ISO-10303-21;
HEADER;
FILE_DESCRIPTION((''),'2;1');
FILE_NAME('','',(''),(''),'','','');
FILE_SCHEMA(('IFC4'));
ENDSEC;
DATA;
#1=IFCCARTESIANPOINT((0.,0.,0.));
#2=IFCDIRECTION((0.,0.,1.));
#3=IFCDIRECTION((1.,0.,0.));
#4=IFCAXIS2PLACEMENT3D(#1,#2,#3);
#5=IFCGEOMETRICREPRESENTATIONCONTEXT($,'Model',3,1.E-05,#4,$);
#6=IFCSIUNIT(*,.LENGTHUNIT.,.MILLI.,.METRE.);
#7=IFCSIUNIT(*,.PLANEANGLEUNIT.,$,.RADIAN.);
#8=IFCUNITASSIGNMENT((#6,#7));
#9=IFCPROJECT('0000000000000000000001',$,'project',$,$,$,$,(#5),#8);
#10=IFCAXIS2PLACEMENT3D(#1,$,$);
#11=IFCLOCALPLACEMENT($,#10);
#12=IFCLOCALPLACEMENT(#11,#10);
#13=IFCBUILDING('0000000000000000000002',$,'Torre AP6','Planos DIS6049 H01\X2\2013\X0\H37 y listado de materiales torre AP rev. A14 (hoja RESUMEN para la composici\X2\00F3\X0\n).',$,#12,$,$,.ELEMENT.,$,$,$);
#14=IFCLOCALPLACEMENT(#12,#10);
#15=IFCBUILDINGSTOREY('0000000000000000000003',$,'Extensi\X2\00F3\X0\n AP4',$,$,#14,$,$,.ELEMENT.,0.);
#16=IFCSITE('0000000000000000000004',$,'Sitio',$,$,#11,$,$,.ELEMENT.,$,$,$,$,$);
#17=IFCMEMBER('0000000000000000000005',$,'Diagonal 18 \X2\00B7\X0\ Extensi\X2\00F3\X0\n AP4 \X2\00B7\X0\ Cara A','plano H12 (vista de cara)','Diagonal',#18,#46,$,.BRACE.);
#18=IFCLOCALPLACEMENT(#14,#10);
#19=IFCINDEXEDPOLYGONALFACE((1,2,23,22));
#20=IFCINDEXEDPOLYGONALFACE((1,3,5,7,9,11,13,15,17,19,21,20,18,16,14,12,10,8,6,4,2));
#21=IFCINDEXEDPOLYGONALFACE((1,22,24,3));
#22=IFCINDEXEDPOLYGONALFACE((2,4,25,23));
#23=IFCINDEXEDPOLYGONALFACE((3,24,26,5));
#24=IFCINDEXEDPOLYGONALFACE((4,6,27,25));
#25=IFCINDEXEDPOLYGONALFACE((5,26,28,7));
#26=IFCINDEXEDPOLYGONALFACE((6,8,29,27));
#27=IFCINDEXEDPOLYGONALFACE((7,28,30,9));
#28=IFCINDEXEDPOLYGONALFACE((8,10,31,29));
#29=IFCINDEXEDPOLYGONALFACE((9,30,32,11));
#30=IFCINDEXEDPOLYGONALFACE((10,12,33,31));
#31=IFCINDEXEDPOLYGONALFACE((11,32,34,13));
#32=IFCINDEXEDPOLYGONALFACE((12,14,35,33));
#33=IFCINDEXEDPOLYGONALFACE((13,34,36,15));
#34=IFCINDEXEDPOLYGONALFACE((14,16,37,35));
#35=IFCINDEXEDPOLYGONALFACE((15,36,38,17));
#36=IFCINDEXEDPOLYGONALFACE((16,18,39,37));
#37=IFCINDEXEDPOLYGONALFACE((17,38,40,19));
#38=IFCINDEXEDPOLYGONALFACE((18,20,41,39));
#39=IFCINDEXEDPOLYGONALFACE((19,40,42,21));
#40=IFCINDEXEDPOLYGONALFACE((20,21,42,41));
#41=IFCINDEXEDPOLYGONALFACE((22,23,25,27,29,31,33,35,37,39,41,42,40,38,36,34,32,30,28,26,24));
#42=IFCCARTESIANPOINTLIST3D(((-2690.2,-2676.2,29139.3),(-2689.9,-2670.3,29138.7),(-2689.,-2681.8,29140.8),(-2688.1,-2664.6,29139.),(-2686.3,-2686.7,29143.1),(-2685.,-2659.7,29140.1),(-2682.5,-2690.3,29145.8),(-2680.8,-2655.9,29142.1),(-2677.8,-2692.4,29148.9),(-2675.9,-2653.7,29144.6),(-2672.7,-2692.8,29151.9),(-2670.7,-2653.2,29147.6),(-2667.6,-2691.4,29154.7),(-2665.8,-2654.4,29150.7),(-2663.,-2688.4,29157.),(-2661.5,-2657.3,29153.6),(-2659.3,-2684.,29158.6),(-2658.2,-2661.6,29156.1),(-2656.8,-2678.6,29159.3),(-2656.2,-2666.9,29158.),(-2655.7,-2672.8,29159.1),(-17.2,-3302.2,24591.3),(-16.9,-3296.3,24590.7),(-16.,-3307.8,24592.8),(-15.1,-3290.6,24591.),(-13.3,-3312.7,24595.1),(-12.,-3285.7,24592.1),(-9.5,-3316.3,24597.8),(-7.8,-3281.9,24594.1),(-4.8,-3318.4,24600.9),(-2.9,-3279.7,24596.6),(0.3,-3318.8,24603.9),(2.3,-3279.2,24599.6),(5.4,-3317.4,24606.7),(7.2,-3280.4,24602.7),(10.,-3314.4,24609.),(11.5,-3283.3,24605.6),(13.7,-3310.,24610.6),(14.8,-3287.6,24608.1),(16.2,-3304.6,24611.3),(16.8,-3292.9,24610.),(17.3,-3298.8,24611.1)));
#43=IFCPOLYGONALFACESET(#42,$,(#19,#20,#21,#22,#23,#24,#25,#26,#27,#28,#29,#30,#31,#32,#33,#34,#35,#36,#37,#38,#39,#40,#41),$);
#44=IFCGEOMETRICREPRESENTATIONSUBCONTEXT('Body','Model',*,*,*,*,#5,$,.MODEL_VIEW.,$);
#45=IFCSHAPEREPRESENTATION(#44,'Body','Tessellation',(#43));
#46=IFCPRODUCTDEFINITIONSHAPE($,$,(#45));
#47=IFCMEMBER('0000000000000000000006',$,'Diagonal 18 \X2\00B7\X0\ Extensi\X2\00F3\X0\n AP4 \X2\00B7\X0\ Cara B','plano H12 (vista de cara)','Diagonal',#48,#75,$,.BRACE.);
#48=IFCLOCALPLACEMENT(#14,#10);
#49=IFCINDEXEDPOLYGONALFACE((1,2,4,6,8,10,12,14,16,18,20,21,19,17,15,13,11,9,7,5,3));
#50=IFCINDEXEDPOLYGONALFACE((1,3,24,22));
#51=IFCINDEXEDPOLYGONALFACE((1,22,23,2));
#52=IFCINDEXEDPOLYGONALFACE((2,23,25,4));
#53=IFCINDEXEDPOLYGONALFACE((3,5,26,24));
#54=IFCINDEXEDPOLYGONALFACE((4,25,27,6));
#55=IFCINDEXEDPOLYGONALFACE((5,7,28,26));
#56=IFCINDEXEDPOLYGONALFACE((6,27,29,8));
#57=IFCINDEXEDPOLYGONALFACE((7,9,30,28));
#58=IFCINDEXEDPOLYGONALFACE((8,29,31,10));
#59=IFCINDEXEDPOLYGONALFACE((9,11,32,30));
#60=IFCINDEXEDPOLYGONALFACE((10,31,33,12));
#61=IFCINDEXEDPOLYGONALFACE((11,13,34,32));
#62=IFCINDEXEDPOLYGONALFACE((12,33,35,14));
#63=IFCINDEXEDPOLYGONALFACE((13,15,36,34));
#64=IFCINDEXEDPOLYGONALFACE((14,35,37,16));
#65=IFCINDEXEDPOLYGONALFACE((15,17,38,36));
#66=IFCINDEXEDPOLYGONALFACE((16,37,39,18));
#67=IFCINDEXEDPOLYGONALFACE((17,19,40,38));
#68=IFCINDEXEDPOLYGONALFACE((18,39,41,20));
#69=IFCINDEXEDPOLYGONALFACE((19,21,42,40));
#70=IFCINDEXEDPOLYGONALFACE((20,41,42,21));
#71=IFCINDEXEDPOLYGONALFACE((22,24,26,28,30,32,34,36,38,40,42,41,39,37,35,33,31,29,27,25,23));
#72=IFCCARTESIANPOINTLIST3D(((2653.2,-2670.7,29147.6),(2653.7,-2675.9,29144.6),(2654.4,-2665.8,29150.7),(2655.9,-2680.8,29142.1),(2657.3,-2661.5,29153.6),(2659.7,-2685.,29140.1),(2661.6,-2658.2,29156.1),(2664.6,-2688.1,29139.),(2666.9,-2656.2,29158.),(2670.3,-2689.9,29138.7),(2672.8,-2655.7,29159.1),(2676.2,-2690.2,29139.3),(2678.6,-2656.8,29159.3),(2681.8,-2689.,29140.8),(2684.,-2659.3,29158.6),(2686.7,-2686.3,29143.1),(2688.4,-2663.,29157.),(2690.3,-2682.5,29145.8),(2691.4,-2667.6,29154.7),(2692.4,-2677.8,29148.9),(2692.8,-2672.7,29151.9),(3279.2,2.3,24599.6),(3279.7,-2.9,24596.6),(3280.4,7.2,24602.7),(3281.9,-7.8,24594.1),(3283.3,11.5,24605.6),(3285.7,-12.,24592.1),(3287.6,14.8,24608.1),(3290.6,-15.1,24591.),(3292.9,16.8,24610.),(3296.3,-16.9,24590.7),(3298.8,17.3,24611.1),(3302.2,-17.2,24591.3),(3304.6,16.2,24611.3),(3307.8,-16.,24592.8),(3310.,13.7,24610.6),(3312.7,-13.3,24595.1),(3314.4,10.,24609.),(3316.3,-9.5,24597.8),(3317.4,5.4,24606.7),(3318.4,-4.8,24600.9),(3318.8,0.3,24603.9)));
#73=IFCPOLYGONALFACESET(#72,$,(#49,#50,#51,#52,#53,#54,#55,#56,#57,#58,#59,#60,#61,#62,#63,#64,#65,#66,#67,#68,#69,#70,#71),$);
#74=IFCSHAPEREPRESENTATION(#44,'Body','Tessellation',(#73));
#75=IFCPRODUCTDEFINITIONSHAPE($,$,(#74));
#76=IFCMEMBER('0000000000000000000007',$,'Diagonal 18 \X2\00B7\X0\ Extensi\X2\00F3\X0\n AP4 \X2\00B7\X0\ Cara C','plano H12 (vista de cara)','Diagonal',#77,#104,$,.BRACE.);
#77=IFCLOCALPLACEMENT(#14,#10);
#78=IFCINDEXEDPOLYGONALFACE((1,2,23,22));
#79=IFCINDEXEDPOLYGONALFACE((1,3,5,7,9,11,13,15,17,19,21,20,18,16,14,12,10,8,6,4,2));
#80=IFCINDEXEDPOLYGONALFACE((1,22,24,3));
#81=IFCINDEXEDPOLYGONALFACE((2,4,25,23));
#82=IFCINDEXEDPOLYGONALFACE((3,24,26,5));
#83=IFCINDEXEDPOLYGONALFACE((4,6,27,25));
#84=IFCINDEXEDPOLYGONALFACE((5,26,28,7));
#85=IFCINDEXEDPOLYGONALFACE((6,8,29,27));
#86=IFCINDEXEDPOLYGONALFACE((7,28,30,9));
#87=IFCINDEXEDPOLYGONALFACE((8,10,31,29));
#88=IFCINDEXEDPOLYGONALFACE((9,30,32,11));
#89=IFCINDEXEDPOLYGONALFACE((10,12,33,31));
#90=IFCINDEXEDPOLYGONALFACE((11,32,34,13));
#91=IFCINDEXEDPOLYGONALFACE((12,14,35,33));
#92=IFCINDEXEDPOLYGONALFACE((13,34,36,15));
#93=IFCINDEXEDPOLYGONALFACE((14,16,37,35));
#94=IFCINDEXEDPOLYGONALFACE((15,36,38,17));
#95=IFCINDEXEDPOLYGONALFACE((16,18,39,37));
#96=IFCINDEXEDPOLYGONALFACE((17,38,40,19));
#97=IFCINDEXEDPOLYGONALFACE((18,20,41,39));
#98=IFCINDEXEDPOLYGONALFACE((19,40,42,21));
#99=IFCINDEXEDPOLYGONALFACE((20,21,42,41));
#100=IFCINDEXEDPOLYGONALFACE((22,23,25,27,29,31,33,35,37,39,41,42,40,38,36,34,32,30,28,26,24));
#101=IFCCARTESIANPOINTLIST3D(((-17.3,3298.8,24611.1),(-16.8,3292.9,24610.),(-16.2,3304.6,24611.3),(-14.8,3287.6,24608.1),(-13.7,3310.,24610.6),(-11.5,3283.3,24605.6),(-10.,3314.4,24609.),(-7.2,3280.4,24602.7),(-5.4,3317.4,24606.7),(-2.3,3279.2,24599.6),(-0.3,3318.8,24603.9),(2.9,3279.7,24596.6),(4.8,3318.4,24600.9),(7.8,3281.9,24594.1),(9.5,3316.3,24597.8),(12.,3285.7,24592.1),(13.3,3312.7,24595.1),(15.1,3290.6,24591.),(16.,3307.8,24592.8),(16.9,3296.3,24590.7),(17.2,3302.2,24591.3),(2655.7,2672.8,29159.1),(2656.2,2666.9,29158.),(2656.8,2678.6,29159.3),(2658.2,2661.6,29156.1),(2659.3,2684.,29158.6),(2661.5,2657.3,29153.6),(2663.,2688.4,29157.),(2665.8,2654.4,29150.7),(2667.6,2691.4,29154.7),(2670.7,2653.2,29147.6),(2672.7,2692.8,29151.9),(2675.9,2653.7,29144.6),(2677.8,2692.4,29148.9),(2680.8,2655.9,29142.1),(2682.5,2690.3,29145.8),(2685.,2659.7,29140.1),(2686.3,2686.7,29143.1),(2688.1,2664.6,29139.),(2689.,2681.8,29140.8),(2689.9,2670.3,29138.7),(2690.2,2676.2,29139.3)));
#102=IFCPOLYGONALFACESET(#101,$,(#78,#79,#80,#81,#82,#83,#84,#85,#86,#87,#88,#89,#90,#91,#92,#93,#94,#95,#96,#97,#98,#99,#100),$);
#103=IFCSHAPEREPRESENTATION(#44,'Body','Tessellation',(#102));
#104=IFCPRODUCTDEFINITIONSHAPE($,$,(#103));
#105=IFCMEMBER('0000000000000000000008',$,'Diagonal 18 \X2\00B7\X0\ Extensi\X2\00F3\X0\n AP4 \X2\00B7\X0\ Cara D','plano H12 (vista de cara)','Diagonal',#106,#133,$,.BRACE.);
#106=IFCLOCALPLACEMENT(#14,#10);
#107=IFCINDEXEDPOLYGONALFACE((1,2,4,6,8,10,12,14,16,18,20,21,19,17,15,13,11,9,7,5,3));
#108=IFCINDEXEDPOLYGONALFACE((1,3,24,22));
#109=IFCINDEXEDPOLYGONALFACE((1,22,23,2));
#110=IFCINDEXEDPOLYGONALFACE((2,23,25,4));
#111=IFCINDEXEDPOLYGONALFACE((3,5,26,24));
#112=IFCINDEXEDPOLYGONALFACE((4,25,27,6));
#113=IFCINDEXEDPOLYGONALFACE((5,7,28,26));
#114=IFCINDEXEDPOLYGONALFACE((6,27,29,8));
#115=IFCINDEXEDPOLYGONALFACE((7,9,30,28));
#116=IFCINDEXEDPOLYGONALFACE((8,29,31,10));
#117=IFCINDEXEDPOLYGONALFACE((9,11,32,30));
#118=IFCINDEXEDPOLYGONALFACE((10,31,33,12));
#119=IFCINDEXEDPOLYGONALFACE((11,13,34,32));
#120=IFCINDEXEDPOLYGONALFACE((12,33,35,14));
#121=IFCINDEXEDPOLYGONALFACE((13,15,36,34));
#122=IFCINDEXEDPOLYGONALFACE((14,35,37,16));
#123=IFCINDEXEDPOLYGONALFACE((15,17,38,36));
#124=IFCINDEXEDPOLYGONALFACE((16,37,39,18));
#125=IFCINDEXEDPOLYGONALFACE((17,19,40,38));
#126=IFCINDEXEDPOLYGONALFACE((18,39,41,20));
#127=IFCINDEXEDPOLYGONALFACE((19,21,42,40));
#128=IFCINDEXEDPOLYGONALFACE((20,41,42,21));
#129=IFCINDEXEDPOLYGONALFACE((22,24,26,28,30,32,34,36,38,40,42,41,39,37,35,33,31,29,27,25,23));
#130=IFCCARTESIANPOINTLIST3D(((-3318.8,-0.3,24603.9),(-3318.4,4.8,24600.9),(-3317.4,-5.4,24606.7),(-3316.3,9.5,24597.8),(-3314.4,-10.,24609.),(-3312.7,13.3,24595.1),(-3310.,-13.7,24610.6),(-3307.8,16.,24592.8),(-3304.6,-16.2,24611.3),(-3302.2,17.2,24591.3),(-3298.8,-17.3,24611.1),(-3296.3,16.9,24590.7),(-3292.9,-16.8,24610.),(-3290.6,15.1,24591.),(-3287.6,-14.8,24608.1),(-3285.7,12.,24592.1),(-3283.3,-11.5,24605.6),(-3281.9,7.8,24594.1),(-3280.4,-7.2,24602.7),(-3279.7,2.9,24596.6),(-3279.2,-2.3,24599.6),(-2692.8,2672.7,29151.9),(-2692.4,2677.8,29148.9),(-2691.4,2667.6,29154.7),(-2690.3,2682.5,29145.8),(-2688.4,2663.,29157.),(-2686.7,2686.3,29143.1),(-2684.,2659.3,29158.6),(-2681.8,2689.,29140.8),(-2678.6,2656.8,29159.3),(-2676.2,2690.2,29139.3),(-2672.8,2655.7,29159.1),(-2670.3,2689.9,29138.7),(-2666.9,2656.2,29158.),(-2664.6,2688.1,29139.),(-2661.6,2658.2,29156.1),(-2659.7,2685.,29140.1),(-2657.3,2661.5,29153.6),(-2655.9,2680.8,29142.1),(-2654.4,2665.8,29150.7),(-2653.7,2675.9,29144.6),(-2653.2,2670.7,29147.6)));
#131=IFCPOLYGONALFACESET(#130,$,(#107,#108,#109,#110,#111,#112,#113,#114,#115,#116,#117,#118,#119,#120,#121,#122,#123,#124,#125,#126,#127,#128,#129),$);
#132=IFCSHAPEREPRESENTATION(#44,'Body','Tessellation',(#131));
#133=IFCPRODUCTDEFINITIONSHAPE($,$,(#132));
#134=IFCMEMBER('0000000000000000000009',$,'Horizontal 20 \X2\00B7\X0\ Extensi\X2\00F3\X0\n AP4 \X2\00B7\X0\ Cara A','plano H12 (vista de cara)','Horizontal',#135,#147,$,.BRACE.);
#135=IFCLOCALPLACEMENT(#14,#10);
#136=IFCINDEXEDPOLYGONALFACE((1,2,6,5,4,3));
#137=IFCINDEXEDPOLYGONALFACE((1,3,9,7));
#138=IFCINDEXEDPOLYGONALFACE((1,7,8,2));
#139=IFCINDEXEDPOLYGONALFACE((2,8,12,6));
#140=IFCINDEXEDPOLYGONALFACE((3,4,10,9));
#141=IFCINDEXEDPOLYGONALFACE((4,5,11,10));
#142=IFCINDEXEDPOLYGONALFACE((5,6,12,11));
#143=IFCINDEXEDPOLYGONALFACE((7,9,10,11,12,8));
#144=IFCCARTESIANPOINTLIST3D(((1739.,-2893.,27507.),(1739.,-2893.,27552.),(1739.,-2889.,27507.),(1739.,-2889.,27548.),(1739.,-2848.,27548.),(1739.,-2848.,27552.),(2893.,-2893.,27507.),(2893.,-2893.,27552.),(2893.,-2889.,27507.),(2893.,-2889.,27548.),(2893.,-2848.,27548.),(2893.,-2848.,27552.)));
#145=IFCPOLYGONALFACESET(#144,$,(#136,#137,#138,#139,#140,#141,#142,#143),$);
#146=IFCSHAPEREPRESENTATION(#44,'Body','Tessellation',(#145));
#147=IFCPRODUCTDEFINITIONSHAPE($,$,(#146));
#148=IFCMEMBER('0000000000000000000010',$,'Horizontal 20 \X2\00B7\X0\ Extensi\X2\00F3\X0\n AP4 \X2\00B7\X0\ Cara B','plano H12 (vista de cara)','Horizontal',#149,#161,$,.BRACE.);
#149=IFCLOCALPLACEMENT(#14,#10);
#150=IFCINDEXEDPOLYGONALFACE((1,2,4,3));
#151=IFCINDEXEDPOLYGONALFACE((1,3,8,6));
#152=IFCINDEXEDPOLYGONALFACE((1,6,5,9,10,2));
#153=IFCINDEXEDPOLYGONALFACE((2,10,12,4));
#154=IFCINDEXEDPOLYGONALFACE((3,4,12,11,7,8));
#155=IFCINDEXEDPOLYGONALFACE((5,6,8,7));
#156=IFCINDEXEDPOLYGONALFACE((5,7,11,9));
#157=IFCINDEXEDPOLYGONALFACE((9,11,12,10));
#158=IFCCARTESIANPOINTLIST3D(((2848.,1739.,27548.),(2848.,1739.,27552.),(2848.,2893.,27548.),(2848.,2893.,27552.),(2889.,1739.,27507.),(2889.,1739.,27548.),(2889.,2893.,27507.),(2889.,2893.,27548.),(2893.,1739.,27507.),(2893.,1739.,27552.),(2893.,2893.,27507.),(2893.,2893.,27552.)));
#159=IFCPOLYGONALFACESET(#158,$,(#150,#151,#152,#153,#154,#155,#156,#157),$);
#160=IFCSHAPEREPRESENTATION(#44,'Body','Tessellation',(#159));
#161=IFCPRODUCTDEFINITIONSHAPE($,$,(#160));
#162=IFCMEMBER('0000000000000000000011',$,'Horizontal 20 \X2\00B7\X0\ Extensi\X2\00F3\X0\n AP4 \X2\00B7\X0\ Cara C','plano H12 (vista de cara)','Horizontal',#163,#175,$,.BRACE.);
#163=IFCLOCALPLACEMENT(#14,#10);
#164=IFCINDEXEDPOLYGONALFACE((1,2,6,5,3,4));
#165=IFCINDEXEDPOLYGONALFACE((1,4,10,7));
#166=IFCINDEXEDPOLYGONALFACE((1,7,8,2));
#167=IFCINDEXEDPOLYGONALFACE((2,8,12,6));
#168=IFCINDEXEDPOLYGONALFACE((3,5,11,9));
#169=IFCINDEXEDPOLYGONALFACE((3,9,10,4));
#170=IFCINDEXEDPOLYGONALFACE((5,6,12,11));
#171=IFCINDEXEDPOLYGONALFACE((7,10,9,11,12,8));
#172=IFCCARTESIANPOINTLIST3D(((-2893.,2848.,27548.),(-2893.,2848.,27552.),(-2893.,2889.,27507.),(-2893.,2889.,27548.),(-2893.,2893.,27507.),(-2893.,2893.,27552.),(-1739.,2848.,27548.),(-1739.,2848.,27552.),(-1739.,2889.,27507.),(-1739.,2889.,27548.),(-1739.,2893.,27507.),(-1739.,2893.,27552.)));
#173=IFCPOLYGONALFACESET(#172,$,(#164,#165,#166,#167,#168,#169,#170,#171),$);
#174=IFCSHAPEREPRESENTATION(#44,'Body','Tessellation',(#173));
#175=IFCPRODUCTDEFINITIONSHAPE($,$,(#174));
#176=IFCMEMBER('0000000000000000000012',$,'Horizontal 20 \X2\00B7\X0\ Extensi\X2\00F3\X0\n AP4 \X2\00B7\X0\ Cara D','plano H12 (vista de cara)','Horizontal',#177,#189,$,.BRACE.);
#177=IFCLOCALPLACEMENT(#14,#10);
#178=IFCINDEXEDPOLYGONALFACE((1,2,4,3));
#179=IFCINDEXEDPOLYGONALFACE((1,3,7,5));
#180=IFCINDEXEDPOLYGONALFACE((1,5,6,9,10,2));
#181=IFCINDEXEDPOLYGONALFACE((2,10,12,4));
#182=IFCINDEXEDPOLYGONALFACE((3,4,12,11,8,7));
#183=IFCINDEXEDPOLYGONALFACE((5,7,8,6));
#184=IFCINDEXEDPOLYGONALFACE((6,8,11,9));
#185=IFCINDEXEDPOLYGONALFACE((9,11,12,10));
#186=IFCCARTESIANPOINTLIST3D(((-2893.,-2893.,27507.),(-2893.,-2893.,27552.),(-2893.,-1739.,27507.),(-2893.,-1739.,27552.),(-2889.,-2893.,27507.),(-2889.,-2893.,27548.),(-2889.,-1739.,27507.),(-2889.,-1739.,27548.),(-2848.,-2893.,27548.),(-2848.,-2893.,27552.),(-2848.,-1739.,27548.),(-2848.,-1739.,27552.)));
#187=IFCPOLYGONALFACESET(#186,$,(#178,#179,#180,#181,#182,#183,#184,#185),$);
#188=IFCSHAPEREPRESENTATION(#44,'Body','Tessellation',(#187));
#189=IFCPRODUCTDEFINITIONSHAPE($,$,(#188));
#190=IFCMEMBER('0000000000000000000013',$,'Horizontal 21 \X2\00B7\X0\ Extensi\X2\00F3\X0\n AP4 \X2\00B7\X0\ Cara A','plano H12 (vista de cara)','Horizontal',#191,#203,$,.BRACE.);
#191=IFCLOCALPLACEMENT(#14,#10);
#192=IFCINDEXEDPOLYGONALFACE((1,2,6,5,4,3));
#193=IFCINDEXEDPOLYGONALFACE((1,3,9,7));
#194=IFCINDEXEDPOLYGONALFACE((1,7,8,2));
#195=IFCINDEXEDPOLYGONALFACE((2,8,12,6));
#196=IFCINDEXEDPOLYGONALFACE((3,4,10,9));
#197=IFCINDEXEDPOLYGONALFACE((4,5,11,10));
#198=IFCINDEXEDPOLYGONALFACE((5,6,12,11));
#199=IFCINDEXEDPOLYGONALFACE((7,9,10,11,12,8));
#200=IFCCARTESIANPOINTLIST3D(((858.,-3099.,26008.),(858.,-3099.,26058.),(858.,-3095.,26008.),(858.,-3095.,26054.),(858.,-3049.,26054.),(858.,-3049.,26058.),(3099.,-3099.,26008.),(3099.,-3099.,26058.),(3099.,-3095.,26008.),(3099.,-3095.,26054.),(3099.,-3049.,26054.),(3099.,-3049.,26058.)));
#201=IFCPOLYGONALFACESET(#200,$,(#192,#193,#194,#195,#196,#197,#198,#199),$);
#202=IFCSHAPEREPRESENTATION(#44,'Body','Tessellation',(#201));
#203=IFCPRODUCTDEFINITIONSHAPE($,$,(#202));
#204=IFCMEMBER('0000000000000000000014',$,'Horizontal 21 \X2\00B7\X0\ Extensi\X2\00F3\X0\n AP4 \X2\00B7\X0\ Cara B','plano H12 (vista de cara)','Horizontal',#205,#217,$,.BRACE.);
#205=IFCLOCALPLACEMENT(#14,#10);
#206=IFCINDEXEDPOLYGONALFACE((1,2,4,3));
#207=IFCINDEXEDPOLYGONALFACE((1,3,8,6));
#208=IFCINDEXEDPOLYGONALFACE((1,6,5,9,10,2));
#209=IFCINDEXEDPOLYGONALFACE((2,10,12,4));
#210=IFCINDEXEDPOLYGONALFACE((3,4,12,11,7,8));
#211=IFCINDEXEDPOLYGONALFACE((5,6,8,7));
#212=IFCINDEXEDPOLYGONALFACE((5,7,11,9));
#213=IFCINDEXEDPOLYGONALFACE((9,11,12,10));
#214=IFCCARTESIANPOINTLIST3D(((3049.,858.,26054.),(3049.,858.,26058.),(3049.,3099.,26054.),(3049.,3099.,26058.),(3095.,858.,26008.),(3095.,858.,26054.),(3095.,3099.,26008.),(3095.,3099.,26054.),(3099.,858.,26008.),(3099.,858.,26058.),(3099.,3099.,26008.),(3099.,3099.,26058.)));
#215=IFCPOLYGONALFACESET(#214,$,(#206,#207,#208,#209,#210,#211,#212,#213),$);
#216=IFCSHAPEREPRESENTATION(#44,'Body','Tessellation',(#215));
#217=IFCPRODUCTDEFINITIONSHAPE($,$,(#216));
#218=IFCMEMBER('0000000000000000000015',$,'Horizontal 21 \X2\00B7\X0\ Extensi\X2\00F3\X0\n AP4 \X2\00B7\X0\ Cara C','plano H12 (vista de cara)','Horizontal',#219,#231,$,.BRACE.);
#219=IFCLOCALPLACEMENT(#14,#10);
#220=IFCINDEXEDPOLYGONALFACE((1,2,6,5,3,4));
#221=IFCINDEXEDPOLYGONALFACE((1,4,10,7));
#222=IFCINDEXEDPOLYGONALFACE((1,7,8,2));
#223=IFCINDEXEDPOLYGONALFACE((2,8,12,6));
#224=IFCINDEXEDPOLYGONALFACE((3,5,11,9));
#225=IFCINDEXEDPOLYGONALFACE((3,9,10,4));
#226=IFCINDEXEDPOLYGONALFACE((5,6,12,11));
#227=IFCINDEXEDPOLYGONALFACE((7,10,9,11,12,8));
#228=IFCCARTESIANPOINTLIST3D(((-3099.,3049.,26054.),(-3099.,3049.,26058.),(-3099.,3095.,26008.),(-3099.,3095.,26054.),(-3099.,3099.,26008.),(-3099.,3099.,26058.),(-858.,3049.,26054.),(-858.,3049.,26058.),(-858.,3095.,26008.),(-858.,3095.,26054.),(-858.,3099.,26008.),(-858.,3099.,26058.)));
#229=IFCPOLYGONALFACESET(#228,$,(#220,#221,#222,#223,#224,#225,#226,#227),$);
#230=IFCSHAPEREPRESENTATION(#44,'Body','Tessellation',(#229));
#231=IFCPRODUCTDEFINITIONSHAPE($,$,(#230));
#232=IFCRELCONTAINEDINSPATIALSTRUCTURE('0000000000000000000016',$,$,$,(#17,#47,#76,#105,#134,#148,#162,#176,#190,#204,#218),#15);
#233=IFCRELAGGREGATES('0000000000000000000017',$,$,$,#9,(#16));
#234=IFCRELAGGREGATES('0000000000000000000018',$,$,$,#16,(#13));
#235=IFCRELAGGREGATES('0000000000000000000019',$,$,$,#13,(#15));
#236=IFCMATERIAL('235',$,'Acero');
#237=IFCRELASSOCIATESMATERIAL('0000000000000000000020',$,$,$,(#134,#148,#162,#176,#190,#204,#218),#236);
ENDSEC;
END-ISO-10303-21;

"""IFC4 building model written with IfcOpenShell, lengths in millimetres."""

from ifc_helpers import new_model, si_unit, frame, frame_2d, origin, origin_with_axes, place, context, subcontext, project, spatial, circle, l_section, extrude, material, element, save


model = new_model("IFC4")

# Units and contexts
model_context = context("Model", 3, precision=1e-05, world=origin_with_axes())
body_context = subcontext(model_context, "Body", "Model", "MODEL_VIEW")
ifc_project = project(units=[si_unit("LENGTHUNIT", "METRE", prefix="MILLI"), si_unit("PLANEANGLEUNIT", "RADIAN")], contexts=[model_context])

# Site, building, storey
site_placement = place(None, origin())
site = spatial("IfcSite", under=ifc_project, at=site_placement, Name="Sitio", CompositionType="ELEMENT")
building_placement = place(site_placement, origin())
building = spatial("IfcBuilding", under=site, at=building_placement, Name="Torre AP6", Description="Planos DIS6049 H01–H37 y listado de materiales torre AP rev. A14 (hoja RESUMEN para la composición).", CompositionType="ELEMENT")
storey_placement = place(building_placement, origin())
storey = spatial("IfcBuildingStorey", under=building, at=storey_placement, Name="Extensión AP4", CompositionType="ELEMENT", Elevation=0.0)

# Members
ifc_material_1 = material(Name="235", Category="Acero")
for number, where, z_axis, x_axis, name in (
    (1, (0.0, -3299.0, 24601.0), (-0.503167, 0.117839, 0.856118), (0.360959, 0.928763, 0.084309), "Diagonal 18 · Extensión AP4 · Cara A"),
    (2, (3299.0, 0.0, 24601.0), (-0.117839, -0.503167, 0.856118), (-0.928763, 0.360959, 0.084309), "Diagonal 18 · Extensión AP4 · Cara B"),
    (3, (0.0, 3299.0, 24601.0), (0.503167, -0.117839, 0.856118), (-0.360959, -0.928763, 0.084309), "Diagonal 18 · Extensión AP4 · Cara C"),
    (4, (-3299.0, 0.0, 24601.0), (0.117839, 0.503167, 0.856118), (0.928763, -0.360959, 0.084309), "Diagonal 18 · Extensión AP4 · Cara D"),
):
    element("IfcMember", number, at=place(storey_placement, frame(where, z_axis=z_axis, x_axis=x_axis)), inside=storey, Name=name, Description="plano H12 (vista de cara)", ObjectType="Diagonal", PredefinedType="BRACE", context=body_context, shape_type="SweptSolid", body=[
        extrude(circle(Radius=20.0), None, (0.0, 0.0, 1.0), 5312.4),
    ])
for number, where, z_axis, x_axis, name in (
    (5, (2893.0, -2893.0, 27552.0), (-1.0, 0.0, 0.0), (0.0, 1.0, 0.0), "Horizontal 20 · Extensión AP4 · Cara A"),
    (6, (2893.0, 2893.0, 27552.0), (0.0, -1.0, 0.0), (-1.0, 0.0, 0.0), "Horizontal 20 · Extensión AP4 · Cara B"),
    (7, (-2893.0, 2893.0, 27552.0), (1.0, 0.0, 0.0), (0.0, -1.0, 0.0), "Horizontal 20 · Extensión AP4 · Cara C"),
    (8, (-2893.0, -2893.0, 27552.0), (0.0, 1.0, 0.0), (1.0, 0.0, 0.0), "Horizontal 20 · Extensión AP4 · Cara D"),
):
    element("IfcMember", number, at=place(storey_placement, frame(where, z_axis=z_axis, x_axis=x_axis)), inside=storey, material=ifc_material_1, Name=name, Description="plano H12 (vista de cara)", ObjectType="Horizontal", PredefinedType="BRACE", context=body_context, shape_type="SweptSolid", body=[
        extrude(l_section(Depth=45.0, Width=45.0, Thickness=4.0, at=frame_2d((22.5, 22.5))), None, (0.0, 0.0, 1.0), 1154.0),
    ])
for number, where, z_axis, x_axis, name in (
    (9, (3099.0, -3099.0, 26058.0), (-1.0, 0.0, 0.0), (0.0, 1.0, 0.0), "Horizontal 21 · Extensión AP4 · Cara A"),
    (10, (3099.0, 3099.0, 26058.0), (0.0, -1.0, 0.0), (-1.0, 0.0, 0.0), "Horizontal 21 · Extensión AP4 · Cara B"),
    (11, (-3099.0, 3099.0, 26058.0), (1.0, 0.0, 0.0), (0.0, -1.0, 0.0), "Horizontal 21 · Extensión AP4 · Cara C"),
):
    element("IfcMember", number, at=place(storey_placement, frame(where, z_axis=z_axis, x_axis=x_axis)), inside=storey, material=ifc_material_1, Name=name, Description="plano H12 (vista de cara)", ObjectType="Horizontal", PredefinedType="BRACE", context=body_context, shape_type="SweptSolid", body=[
        extrude(l_section(Depth=50.0, Width=50.0, Thickness=4.0, at=frame_2d((25.0, 25.0))), None, (0.0, 0.0, 1.0), 2241.0),
    ])

save(model, "model.ifc")
